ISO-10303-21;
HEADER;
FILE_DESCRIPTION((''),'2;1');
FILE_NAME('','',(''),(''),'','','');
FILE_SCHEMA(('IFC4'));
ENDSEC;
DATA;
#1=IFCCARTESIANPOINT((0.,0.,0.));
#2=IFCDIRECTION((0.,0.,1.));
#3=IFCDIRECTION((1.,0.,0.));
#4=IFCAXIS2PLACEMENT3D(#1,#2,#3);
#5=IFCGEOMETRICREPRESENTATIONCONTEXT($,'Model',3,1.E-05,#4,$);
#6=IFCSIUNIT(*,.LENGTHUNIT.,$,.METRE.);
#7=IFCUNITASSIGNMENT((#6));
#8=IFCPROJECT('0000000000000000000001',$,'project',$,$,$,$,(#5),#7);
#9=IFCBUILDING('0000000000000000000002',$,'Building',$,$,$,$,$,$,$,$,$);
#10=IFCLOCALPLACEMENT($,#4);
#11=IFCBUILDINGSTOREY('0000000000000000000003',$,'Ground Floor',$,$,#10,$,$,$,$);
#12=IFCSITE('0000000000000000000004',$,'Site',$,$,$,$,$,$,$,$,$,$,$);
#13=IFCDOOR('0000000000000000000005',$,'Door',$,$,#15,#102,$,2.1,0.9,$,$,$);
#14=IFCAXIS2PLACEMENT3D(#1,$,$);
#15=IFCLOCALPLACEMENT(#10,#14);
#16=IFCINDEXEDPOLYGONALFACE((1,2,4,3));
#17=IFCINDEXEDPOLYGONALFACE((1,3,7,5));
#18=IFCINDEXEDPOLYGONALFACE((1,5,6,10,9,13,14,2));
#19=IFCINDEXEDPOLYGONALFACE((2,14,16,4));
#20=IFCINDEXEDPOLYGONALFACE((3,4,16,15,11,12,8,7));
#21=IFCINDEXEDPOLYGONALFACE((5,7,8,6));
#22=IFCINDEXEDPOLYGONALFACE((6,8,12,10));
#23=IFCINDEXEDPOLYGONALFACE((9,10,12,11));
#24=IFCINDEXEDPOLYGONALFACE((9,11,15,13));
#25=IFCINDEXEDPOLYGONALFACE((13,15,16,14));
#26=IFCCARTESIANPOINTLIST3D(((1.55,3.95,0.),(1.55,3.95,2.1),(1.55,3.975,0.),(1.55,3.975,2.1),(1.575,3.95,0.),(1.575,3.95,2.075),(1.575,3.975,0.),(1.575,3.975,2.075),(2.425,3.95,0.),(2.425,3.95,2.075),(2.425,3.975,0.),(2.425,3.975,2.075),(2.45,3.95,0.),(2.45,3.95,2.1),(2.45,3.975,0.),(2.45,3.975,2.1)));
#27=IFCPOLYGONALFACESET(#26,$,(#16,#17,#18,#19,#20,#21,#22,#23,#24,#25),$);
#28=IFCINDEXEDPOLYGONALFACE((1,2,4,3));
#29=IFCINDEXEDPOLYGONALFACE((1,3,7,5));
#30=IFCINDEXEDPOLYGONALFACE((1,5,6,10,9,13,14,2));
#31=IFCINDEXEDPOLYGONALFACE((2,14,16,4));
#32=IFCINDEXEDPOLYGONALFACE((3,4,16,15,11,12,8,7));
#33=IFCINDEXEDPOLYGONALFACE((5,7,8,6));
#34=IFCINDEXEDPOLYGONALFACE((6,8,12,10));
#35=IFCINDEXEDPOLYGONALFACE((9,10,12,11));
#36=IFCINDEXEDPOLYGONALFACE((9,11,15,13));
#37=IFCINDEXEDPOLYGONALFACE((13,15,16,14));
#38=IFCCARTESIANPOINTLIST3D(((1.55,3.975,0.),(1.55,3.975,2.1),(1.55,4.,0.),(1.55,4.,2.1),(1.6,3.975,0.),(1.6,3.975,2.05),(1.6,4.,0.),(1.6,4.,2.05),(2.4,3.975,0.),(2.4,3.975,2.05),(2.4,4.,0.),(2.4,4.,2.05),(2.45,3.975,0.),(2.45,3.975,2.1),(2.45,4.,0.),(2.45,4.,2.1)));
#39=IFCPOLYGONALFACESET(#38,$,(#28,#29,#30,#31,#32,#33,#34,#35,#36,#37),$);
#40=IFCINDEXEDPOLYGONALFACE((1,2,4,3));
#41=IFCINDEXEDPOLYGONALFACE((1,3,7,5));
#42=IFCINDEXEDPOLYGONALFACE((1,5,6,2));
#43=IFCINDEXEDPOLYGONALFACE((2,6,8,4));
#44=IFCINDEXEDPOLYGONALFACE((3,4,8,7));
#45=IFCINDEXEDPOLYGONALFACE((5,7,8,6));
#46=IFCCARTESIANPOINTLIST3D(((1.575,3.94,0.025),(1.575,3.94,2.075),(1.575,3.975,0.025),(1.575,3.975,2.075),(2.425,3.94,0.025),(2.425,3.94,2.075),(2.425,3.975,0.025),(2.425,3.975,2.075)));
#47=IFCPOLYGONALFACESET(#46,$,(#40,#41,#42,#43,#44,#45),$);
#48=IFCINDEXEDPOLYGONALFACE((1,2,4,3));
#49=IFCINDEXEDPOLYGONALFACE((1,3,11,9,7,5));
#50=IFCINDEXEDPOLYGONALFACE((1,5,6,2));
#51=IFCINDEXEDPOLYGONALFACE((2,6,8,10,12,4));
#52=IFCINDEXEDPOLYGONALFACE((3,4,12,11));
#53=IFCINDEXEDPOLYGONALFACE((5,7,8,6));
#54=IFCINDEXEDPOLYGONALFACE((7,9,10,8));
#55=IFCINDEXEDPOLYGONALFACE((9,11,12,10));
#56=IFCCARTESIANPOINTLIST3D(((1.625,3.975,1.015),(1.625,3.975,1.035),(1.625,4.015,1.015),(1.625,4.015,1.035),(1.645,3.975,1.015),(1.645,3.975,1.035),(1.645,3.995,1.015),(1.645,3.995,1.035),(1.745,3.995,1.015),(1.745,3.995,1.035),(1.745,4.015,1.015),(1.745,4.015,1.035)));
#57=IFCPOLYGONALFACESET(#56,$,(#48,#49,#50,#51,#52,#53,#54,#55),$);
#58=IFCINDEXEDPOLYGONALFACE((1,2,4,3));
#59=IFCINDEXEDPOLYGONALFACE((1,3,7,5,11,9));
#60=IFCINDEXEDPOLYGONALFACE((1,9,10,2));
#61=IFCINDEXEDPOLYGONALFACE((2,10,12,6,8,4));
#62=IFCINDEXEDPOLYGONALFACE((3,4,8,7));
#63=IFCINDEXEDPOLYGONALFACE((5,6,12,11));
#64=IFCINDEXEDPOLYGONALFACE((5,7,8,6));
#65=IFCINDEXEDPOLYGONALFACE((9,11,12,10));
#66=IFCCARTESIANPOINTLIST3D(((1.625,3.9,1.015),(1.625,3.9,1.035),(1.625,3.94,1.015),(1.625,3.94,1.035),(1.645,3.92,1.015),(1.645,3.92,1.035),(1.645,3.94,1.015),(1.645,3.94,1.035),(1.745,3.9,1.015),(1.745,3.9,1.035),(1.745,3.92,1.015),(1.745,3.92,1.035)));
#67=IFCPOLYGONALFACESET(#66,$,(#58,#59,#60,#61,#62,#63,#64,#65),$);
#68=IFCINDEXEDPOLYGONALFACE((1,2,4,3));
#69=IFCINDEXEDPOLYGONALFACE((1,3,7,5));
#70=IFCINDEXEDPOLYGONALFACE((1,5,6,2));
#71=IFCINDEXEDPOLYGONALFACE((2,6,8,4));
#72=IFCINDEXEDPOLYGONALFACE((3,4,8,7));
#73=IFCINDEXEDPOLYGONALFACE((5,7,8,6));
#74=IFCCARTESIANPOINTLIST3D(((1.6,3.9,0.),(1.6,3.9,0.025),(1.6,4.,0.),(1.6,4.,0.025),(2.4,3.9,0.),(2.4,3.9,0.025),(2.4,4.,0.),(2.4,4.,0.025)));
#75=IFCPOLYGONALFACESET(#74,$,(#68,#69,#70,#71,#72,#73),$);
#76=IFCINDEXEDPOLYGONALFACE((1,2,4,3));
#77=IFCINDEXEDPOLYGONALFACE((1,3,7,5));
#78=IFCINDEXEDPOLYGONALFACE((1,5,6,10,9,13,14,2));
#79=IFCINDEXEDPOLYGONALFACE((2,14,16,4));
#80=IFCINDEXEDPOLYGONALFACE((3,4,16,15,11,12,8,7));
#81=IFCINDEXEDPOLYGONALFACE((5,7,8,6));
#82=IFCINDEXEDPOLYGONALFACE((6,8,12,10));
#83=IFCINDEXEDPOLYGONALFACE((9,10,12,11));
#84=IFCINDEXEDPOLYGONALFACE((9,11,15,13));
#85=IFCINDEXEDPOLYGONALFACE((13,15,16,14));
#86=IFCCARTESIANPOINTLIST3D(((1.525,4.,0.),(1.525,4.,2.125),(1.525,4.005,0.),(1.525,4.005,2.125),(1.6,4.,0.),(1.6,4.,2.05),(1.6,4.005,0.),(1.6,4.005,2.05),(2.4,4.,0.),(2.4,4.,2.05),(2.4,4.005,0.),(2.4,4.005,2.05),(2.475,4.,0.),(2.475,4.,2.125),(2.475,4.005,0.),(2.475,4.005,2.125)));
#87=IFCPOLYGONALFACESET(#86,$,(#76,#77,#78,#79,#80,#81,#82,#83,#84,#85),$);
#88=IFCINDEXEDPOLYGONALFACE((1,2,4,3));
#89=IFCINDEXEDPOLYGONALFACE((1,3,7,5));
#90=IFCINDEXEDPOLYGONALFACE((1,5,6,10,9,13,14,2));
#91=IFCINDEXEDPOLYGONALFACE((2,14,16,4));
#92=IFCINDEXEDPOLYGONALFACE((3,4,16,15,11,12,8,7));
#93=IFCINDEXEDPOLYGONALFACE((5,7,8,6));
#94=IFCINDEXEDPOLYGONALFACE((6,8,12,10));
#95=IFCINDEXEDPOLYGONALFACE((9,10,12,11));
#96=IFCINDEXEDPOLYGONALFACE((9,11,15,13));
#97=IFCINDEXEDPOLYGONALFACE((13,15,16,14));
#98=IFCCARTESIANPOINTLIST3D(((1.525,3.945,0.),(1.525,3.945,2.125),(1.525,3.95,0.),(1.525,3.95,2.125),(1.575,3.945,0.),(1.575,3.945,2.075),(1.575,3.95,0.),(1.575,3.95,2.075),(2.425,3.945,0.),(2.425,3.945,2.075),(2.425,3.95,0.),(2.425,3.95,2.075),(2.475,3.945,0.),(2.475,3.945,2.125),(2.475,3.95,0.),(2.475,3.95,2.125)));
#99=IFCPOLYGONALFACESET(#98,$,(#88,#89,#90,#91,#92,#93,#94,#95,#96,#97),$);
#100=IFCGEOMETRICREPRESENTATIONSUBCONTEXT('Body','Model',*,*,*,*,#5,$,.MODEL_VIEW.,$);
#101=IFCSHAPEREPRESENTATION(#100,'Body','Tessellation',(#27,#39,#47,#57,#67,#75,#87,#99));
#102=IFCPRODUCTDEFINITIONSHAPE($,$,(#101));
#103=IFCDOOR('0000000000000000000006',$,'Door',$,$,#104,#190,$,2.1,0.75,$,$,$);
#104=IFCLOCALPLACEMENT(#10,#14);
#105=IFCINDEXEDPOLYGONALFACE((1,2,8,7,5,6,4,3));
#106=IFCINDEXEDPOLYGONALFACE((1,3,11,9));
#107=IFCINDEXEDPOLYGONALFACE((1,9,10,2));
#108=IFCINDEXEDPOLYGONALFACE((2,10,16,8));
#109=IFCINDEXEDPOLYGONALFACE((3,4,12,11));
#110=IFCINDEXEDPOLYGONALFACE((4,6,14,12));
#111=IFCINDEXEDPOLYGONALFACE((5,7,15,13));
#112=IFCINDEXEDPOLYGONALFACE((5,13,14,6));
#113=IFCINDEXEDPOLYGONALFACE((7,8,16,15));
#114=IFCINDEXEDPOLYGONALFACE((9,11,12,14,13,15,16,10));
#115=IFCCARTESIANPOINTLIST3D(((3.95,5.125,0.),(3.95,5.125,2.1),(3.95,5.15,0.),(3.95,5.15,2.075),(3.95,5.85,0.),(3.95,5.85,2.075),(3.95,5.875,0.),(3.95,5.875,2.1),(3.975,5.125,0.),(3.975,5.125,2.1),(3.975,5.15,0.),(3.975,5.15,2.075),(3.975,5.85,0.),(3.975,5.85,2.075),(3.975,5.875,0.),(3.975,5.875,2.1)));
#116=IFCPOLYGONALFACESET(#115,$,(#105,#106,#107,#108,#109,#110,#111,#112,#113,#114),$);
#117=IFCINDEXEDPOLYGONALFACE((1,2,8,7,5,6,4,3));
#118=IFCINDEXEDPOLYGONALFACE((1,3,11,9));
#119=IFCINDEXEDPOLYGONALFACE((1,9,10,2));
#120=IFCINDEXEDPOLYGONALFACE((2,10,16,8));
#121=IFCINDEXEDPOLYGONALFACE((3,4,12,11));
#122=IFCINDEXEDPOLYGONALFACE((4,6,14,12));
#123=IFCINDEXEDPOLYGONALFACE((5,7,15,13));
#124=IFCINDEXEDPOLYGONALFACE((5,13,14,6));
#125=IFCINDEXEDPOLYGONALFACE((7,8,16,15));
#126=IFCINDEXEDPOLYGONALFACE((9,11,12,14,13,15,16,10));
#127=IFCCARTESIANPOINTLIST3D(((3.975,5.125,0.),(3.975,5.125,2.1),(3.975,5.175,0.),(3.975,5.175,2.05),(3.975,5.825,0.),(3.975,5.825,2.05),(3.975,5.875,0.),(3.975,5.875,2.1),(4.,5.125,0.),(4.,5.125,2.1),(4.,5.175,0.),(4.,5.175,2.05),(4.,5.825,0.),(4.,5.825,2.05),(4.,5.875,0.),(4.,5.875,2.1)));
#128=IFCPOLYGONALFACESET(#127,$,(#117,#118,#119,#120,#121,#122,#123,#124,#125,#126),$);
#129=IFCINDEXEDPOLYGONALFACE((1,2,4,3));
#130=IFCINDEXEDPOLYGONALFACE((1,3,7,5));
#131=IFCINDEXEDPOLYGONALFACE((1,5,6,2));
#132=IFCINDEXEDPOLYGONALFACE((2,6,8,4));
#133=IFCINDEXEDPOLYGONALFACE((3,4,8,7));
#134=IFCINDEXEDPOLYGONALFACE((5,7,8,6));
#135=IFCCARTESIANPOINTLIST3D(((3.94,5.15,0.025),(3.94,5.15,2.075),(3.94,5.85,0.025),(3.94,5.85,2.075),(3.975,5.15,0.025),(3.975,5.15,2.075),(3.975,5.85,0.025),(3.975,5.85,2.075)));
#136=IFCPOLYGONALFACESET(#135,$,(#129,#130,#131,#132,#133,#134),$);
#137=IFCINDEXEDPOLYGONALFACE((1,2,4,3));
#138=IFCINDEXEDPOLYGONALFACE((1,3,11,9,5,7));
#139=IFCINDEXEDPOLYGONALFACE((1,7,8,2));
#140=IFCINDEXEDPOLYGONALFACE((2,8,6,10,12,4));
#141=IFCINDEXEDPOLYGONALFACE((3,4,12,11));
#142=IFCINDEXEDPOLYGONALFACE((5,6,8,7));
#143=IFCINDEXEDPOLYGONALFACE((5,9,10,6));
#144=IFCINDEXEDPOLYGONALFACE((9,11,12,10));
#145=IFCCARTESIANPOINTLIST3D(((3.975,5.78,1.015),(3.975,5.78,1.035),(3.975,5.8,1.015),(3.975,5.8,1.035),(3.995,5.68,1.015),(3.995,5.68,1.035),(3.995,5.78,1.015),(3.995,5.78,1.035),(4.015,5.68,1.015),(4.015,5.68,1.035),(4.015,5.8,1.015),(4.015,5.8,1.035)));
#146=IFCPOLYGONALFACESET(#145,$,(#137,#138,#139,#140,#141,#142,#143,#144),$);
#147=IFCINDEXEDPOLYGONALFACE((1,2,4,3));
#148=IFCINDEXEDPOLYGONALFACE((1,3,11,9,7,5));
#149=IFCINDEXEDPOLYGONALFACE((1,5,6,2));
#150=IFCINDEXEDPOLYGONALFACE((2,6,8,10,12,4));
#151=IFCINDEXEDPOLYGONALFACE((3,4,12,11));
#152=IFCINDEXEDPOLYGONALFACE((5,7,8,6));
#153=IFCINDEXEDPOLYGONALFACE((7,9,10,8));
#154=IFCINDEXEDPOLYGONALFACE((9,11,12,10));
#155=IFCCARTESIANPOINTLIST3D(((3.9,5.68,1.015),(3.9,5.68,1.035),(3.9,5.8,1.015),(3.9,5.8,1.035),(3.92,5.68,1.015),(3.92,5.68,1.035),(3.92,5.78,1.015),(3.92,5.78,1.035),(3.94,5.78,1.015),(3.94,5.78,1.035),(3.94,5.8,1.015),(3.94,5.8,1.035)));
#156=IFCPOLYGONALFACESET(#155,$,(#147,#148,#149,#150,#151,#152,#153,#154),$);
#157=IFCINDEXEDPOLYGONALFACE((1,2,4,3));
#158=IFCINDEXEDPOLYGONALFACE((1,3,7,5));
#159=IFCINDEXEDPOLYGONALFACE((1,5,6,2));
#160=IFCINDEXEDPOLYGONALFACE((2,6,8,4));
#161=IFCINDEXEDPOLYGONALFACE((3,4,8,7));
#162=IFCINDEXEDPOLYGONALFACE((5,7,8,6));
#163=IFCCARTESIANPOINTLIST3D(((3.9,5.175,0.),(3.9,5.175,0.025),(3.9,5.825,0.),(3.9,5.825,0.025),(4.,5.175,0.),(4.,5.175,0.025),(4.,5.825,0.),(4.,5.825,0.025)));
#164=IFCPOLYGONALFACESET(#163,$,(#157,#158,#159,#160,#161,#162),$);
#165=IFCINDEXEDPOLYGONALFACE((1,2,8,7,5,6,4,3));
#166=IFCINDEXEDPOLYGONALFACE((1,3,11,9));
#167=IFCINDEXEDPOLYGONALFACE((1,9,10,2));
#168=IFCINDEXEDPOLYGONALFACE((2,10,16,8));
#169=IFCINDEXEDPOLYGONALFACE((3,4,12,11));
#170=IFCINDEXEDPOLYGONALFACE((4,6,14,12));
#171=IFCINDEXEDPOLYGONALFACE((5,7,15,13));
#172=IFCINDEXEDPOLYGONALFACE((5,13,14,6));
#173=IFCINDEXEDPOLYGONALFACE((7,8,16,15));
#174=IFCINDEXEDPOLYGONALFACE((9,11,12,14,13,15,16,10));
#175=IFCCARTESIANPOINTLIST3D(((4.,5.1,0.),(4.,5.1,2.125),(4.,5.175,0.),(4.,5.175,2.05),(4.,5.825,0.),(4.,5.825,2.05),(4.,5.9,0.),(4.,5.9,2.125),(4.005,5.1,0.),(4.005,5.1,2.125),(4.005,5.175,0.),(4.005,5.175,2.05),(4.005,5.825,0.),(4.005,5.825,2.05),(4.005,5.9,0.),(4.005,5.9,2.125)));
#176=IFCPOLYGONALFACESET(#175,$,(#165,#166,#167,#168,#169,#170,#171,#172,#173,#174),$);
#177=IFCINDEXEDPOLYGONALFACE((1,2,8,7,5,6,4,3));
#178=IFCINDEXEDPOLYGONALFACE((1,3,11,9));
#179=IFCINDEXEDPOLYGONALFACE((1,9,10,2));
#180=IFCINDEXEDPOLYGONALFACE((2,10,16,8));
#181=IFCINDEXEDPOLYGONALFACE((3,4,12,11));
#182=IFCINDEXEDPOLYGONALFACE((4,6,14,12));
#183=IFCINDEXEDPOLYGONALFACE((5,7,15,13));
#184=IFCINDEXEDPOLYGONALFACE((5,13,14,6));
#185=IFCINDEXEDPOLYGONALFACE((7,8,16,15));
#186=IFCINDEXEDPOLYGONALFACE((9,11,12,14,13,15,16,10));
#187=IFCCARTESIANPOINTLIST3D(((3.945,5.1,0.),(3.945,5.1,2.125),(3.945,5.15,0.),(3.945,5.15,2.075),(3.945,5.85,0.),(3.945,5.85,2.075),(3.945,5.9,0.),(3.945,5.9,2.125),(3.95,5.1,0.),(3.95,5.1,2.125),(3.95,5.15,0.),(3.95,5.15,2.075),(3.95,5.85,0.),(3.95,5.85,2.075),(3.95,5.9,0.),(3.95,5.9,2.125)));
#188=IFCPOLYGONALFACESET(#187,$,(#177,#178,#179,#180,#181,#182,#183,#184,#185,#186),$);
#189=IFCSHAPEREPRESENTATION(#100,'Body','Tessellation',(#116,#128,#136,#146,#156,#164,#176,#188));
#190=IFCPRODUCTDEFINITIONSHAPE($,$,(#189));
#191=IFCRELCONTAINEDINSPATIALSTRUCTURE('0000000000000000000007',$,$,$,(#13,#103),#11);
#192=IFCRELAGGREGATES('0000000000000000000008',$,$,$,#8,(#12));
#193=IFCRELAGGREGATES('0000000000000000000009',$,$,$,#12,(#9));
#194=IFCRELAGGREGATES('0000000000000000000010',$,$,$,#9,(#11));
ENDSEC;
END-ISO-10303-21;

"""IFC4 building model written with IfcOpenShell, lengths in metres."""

from ifc_helpers import new_model, si_unit, frame, origin_with_axes, place, context, subcontext, project, spatial, line, indexed_curve, outline, extrude, element, save


model = new_model("IFC4")

# Units and contexts
model_context = context("Model", 3, precision=1e-05, world=origin_with_axes())
body_context = subcontext(model_context, "Body", "Model", "MODEL_VIEW")
ifc_project = project(units=[si_unit("LENGTHUNIT", "METRE")], contexts=[model_context])

# Site, building, storey
site = spatial("IfcSite", under=ifc_project, Name="Site")
building = spatial("IfcBuilding", under=site, Name="Building")
storey_placement = place(None, origin_with_axes())
storey = spatial("IfcBuildingStorey", under=building, at=storey_placement, Name="Ground Floor")

# Doors
door_1_placement = place(storey_placement, frame((2.45, 4.0, 0.0), z_axis=(0.0, 0.0, 1.0), x_axis=(-1.0, 0.0, 0.0)))
element("IfcDoor", 1, at=door_1_placement, inside=storey, Name="Door", OverallHeight=2.1, OverallWidth=0.9, context=body_context, shape_type="SweptSolid", body=[
    extrude(outline(indexed_curve([(0.0, 0.0), (0.0, 2.1), (0.9, 2.1), (0.9, 0.0), (0.875, 0.0), (0.875, 2.075), (0.025, 2.075), (0.025, 0.0)], segments=[line(1, 2, 3, 4, 5, 6, 7, 8, 1)])), frame((0.0, 0.025, 0.0), z_axis=(0.0, -1.0, 0.0), x_axis=(1.0, 0.0, 0.0)), (0.0, 0.0, -1.0), 0.025),
    extrude(outline(indexed_curve([(0.0, 0.0), (0.0, 2.1), (0.9, 2.1), (0.9, 0.0), (0.85, 0.0), (0.85, 2.05), (0.05, 2.05), (0.05, 0.0)], segments=[line(1, 2, 3, 4, 5, 6, 7, 8, 1)])), frame((0.0, 0.0, 0.0), z_axis=(0.0, -1.0, 0.0), x_axis=(1.0, 0.0, 0.0)), (0.0, 0.0, -1.0), 0.025),
    extrude(outline(indexed_curve([(0.0, 0.0), (0.85, 0.0), (0.85, 0.035), (0.0, 0.035)], segments=[line(1, 2, 3, 4, 1)])), frame((0.025, 0.025, 0.025), z_axis=(0.0, 0.0, 1.0), x_axis=(1.0, 0.0, 0.0)), (0.0, 0.0, 1.0), 2.05),
    extrude(outline(indexed_curve([(0.0, 0.0), (0.0, -0.04), (-0.12, -0.04), (-0.12, -0.02), (-0.02, -0.02), (-0.02, 0.0)], segments=[line(1, 2, 3, 4, 5, 6, 1)])), frame((0.825, 0.025, 1.015), z_axis=(0.0, 0.0, 1.0), x_axis=(1.0, 0.0, 0.0)), (0.0, 0.0, 1.0), 0.02),
    extrude(outline(indexed_curve([(0.0, 0.0), (0.0, 0.04), (-0.12, 0.04), (-0.12, 0.02), (-0.02, 0.02), (-0.02, 0.0)], segments=[line(1, 2, 3, 4, 5, 6, 1)])), frame((0.825, 0.06, 1.015), z_axis=(0.0, 0.0, 1.0), x_axis=(1.0, 0.0, 0.0)), (0.0, 0.0, 1.0), 0.02),
    extrude(outline(indexed_curve([(0.0, 0.0), (0.8, 0.0), (0.8, 0.1), (0.0, 0.1)], segments=[line(1, 2, 3, 4, 1)])), frame((0.05, 0.0, 0.0), z_axis=(0.0, 0.0, 1.0), x_axis=(1.0, 0.0, 0.0)), (0.0, 0.0, 1.0), 0.025),
    extrude(outline(indexed_curve([(0.0, 0.0), (0.0, 2.125), (0.95, 2.125), (0.95, 0.0), (0.875, 0.0), (0.875, 2.05), (0.075, 2.05), (0.075, 0.0)], segments=[line(1, 2, 3, 4, 5, 6, 7, 8, 1)])), frame((-0.025, -0.005, 0.0), z_axis=(0.0, -1.0, 0.0), x_axis=(1.0, 0.0, 0.0)), (0.0, 0.0, -1.0), 0.005),
    extrude(outline(indexed_curve([(0.0, 0.0), (0.0, 2.125), (0.95, 2.125), (0.95, 0.0), (0.9, 0.0), (0.9, 2.075), (0.05, 2.075), (0.05, 0.0)], segments=[line(1, 2, 3, 4, 5, 6, 7, 8, 1)])), frame((-0.025, 0.05, 0.0), z_axis=(0.0, -1.0, 0.0), x_axis=(1.0, 0.0, 0.0)), (0.0, 0.0, -1.0), 0.005),
])
door_2_placement = place(storey_placement, frame((4.0, 5.125, 0.0), z_axis=(0.0, 0.0, 1.0), x_axis=(0.0, 1.0, 0.0)))
element("IfcDoor", 2, at=door_2_placement, inside=storey, Name="Door", OverallHeight=2.1, OverallWidth=0.75, context=body_context, shape_type="SweptSolid", body=[
    extrude(outline(indexed_curve([(0.0, 0.0), (0.0, 2.1), (0.75, 2.1), (0.75, 0.0), (0.725, 0.0), (0.725, 2.075), (0.025, 2.075), (0.025, 0.0)], segments=[line(1, 2, 3, 4, 5, 6, 7, 8, 1)])), frame((0.0, 0.025, 0.0), z_axis=(0.0, -1.0, 0.0), x_axis=(1.0, 0.0, 0.0)), (0.0, 0.0, -1.0), 0.025),
    extrude(outline(indexed_curve([(0.0, 0.0), (0.0, 2.1), (0.75, 2.1), (0.75, 0.0), (0.7, 0.0), (0.7, 2.05), (0.05, 2.05), (0.05, 0.0)], segments=[line(1, 2, 3, 4, 5, 6, 7, 8, 1)])), frame((0.0, 0.0, 0.0), z_axis=(0.0, -1.0, 0.0), x_axis=(1.0, 0.0, 0.0)), (0.0, 0.0, -1.0), 0.025),
    extrude(outline(indexed_curve([(0.0, 0.0), (0.7, 0.0), (0.7, 0.035), (0.0, 0.035)], segments=[line(1, 2, 3, 4, 1)])), frame((0.025, 0.025, 0.025), z_axis=(0.0, 0.0, 1.0), x_axis=(1.0, 0.0, 0.0)), (0.0, 0.0, 1.0), 2.05),
    extrude(outline(indexed_curve([(0.0, 0.0), (0.0, -0.04), (-0.12, -0.04), (-0.12, -0.02), (-0.02, -0.02), (-0.02, 0.0)], segments=[line(1, 2, 3, 4, 5, 6, 1)])), frame((0.675, 0.025, 1.015), z_axis=(0.0, 0.0, 1.0), x_axis=(1.0, 0.0, 0.0)), (0.0, 0.0, 1.0), 0.02),
    extrude(outline(indexed_curve([(0.0, 0.0), (0.0, 0.04), (-0.12, 0.04), (-0.12, 0.02), (-0.02, 0.02), (-0.02, 0.0)], segments=[line(1, 2, 3, 4, 5, 6, 1)])), frame((0.675, 0.06, 1.015), z_axis=(0.0, 0.0, 1.0), x_axis=(1.0, 0.0, 0.0)), (0.0, 0.0, 1.0), 0.02),
    extrude(outline(indexed_curve([(0.0, 0.0), (0.65, 0.0), (0.65, 0.1), (0.0, 0.1)], segments=[line(1, 2, 3, 4, 1)])), frame((0.05, 0.0, 0.0), z_axis=(0.0, 0.0, 1.0), x_axis=(1.0, 0.0, 0.0)), (0.0, 0.0, 1.0), 0.025),
    extrude(outline(indexed_curve([(0.0, 0.0), (0.0, 2.125), (0.8, 2.125), (0.8, 0.0), (0.725, 0.0), (0.725, 2.05), (0.075, 2.05), (0.075, 0.0)], segments=[line(1, 2, 3, 4, 5, 6, 7, 8, 1)])), frame((-0.025, -0.005, 0.0), z_axis=(0.0, -1.0, 0.0), x_axis=(1.0, 0.0, 0.0)), (0.0, 0.0, -1.0), 0.005),
    extrude(outline(indexed_curve([(0.0, 0.0), (0.0, 2.125), (0.8, 2.125), (0.8, 0.0), (0.75, 0.0), (0.75, 2.075), (0.05, 2.075), (0.05, 0.0)], segments=[line(1, 2, 3, 4, 5, 6, 7, 8, 1)])), frame((-0.025, 0.05, 0.0), z_axis=(0.0, -1.0, 0.0), x_axis=(1.0, 0.0, 0.0)), (0.0, 0.0, -1.0), 0.005),
])

save(model, "model.ifc")
